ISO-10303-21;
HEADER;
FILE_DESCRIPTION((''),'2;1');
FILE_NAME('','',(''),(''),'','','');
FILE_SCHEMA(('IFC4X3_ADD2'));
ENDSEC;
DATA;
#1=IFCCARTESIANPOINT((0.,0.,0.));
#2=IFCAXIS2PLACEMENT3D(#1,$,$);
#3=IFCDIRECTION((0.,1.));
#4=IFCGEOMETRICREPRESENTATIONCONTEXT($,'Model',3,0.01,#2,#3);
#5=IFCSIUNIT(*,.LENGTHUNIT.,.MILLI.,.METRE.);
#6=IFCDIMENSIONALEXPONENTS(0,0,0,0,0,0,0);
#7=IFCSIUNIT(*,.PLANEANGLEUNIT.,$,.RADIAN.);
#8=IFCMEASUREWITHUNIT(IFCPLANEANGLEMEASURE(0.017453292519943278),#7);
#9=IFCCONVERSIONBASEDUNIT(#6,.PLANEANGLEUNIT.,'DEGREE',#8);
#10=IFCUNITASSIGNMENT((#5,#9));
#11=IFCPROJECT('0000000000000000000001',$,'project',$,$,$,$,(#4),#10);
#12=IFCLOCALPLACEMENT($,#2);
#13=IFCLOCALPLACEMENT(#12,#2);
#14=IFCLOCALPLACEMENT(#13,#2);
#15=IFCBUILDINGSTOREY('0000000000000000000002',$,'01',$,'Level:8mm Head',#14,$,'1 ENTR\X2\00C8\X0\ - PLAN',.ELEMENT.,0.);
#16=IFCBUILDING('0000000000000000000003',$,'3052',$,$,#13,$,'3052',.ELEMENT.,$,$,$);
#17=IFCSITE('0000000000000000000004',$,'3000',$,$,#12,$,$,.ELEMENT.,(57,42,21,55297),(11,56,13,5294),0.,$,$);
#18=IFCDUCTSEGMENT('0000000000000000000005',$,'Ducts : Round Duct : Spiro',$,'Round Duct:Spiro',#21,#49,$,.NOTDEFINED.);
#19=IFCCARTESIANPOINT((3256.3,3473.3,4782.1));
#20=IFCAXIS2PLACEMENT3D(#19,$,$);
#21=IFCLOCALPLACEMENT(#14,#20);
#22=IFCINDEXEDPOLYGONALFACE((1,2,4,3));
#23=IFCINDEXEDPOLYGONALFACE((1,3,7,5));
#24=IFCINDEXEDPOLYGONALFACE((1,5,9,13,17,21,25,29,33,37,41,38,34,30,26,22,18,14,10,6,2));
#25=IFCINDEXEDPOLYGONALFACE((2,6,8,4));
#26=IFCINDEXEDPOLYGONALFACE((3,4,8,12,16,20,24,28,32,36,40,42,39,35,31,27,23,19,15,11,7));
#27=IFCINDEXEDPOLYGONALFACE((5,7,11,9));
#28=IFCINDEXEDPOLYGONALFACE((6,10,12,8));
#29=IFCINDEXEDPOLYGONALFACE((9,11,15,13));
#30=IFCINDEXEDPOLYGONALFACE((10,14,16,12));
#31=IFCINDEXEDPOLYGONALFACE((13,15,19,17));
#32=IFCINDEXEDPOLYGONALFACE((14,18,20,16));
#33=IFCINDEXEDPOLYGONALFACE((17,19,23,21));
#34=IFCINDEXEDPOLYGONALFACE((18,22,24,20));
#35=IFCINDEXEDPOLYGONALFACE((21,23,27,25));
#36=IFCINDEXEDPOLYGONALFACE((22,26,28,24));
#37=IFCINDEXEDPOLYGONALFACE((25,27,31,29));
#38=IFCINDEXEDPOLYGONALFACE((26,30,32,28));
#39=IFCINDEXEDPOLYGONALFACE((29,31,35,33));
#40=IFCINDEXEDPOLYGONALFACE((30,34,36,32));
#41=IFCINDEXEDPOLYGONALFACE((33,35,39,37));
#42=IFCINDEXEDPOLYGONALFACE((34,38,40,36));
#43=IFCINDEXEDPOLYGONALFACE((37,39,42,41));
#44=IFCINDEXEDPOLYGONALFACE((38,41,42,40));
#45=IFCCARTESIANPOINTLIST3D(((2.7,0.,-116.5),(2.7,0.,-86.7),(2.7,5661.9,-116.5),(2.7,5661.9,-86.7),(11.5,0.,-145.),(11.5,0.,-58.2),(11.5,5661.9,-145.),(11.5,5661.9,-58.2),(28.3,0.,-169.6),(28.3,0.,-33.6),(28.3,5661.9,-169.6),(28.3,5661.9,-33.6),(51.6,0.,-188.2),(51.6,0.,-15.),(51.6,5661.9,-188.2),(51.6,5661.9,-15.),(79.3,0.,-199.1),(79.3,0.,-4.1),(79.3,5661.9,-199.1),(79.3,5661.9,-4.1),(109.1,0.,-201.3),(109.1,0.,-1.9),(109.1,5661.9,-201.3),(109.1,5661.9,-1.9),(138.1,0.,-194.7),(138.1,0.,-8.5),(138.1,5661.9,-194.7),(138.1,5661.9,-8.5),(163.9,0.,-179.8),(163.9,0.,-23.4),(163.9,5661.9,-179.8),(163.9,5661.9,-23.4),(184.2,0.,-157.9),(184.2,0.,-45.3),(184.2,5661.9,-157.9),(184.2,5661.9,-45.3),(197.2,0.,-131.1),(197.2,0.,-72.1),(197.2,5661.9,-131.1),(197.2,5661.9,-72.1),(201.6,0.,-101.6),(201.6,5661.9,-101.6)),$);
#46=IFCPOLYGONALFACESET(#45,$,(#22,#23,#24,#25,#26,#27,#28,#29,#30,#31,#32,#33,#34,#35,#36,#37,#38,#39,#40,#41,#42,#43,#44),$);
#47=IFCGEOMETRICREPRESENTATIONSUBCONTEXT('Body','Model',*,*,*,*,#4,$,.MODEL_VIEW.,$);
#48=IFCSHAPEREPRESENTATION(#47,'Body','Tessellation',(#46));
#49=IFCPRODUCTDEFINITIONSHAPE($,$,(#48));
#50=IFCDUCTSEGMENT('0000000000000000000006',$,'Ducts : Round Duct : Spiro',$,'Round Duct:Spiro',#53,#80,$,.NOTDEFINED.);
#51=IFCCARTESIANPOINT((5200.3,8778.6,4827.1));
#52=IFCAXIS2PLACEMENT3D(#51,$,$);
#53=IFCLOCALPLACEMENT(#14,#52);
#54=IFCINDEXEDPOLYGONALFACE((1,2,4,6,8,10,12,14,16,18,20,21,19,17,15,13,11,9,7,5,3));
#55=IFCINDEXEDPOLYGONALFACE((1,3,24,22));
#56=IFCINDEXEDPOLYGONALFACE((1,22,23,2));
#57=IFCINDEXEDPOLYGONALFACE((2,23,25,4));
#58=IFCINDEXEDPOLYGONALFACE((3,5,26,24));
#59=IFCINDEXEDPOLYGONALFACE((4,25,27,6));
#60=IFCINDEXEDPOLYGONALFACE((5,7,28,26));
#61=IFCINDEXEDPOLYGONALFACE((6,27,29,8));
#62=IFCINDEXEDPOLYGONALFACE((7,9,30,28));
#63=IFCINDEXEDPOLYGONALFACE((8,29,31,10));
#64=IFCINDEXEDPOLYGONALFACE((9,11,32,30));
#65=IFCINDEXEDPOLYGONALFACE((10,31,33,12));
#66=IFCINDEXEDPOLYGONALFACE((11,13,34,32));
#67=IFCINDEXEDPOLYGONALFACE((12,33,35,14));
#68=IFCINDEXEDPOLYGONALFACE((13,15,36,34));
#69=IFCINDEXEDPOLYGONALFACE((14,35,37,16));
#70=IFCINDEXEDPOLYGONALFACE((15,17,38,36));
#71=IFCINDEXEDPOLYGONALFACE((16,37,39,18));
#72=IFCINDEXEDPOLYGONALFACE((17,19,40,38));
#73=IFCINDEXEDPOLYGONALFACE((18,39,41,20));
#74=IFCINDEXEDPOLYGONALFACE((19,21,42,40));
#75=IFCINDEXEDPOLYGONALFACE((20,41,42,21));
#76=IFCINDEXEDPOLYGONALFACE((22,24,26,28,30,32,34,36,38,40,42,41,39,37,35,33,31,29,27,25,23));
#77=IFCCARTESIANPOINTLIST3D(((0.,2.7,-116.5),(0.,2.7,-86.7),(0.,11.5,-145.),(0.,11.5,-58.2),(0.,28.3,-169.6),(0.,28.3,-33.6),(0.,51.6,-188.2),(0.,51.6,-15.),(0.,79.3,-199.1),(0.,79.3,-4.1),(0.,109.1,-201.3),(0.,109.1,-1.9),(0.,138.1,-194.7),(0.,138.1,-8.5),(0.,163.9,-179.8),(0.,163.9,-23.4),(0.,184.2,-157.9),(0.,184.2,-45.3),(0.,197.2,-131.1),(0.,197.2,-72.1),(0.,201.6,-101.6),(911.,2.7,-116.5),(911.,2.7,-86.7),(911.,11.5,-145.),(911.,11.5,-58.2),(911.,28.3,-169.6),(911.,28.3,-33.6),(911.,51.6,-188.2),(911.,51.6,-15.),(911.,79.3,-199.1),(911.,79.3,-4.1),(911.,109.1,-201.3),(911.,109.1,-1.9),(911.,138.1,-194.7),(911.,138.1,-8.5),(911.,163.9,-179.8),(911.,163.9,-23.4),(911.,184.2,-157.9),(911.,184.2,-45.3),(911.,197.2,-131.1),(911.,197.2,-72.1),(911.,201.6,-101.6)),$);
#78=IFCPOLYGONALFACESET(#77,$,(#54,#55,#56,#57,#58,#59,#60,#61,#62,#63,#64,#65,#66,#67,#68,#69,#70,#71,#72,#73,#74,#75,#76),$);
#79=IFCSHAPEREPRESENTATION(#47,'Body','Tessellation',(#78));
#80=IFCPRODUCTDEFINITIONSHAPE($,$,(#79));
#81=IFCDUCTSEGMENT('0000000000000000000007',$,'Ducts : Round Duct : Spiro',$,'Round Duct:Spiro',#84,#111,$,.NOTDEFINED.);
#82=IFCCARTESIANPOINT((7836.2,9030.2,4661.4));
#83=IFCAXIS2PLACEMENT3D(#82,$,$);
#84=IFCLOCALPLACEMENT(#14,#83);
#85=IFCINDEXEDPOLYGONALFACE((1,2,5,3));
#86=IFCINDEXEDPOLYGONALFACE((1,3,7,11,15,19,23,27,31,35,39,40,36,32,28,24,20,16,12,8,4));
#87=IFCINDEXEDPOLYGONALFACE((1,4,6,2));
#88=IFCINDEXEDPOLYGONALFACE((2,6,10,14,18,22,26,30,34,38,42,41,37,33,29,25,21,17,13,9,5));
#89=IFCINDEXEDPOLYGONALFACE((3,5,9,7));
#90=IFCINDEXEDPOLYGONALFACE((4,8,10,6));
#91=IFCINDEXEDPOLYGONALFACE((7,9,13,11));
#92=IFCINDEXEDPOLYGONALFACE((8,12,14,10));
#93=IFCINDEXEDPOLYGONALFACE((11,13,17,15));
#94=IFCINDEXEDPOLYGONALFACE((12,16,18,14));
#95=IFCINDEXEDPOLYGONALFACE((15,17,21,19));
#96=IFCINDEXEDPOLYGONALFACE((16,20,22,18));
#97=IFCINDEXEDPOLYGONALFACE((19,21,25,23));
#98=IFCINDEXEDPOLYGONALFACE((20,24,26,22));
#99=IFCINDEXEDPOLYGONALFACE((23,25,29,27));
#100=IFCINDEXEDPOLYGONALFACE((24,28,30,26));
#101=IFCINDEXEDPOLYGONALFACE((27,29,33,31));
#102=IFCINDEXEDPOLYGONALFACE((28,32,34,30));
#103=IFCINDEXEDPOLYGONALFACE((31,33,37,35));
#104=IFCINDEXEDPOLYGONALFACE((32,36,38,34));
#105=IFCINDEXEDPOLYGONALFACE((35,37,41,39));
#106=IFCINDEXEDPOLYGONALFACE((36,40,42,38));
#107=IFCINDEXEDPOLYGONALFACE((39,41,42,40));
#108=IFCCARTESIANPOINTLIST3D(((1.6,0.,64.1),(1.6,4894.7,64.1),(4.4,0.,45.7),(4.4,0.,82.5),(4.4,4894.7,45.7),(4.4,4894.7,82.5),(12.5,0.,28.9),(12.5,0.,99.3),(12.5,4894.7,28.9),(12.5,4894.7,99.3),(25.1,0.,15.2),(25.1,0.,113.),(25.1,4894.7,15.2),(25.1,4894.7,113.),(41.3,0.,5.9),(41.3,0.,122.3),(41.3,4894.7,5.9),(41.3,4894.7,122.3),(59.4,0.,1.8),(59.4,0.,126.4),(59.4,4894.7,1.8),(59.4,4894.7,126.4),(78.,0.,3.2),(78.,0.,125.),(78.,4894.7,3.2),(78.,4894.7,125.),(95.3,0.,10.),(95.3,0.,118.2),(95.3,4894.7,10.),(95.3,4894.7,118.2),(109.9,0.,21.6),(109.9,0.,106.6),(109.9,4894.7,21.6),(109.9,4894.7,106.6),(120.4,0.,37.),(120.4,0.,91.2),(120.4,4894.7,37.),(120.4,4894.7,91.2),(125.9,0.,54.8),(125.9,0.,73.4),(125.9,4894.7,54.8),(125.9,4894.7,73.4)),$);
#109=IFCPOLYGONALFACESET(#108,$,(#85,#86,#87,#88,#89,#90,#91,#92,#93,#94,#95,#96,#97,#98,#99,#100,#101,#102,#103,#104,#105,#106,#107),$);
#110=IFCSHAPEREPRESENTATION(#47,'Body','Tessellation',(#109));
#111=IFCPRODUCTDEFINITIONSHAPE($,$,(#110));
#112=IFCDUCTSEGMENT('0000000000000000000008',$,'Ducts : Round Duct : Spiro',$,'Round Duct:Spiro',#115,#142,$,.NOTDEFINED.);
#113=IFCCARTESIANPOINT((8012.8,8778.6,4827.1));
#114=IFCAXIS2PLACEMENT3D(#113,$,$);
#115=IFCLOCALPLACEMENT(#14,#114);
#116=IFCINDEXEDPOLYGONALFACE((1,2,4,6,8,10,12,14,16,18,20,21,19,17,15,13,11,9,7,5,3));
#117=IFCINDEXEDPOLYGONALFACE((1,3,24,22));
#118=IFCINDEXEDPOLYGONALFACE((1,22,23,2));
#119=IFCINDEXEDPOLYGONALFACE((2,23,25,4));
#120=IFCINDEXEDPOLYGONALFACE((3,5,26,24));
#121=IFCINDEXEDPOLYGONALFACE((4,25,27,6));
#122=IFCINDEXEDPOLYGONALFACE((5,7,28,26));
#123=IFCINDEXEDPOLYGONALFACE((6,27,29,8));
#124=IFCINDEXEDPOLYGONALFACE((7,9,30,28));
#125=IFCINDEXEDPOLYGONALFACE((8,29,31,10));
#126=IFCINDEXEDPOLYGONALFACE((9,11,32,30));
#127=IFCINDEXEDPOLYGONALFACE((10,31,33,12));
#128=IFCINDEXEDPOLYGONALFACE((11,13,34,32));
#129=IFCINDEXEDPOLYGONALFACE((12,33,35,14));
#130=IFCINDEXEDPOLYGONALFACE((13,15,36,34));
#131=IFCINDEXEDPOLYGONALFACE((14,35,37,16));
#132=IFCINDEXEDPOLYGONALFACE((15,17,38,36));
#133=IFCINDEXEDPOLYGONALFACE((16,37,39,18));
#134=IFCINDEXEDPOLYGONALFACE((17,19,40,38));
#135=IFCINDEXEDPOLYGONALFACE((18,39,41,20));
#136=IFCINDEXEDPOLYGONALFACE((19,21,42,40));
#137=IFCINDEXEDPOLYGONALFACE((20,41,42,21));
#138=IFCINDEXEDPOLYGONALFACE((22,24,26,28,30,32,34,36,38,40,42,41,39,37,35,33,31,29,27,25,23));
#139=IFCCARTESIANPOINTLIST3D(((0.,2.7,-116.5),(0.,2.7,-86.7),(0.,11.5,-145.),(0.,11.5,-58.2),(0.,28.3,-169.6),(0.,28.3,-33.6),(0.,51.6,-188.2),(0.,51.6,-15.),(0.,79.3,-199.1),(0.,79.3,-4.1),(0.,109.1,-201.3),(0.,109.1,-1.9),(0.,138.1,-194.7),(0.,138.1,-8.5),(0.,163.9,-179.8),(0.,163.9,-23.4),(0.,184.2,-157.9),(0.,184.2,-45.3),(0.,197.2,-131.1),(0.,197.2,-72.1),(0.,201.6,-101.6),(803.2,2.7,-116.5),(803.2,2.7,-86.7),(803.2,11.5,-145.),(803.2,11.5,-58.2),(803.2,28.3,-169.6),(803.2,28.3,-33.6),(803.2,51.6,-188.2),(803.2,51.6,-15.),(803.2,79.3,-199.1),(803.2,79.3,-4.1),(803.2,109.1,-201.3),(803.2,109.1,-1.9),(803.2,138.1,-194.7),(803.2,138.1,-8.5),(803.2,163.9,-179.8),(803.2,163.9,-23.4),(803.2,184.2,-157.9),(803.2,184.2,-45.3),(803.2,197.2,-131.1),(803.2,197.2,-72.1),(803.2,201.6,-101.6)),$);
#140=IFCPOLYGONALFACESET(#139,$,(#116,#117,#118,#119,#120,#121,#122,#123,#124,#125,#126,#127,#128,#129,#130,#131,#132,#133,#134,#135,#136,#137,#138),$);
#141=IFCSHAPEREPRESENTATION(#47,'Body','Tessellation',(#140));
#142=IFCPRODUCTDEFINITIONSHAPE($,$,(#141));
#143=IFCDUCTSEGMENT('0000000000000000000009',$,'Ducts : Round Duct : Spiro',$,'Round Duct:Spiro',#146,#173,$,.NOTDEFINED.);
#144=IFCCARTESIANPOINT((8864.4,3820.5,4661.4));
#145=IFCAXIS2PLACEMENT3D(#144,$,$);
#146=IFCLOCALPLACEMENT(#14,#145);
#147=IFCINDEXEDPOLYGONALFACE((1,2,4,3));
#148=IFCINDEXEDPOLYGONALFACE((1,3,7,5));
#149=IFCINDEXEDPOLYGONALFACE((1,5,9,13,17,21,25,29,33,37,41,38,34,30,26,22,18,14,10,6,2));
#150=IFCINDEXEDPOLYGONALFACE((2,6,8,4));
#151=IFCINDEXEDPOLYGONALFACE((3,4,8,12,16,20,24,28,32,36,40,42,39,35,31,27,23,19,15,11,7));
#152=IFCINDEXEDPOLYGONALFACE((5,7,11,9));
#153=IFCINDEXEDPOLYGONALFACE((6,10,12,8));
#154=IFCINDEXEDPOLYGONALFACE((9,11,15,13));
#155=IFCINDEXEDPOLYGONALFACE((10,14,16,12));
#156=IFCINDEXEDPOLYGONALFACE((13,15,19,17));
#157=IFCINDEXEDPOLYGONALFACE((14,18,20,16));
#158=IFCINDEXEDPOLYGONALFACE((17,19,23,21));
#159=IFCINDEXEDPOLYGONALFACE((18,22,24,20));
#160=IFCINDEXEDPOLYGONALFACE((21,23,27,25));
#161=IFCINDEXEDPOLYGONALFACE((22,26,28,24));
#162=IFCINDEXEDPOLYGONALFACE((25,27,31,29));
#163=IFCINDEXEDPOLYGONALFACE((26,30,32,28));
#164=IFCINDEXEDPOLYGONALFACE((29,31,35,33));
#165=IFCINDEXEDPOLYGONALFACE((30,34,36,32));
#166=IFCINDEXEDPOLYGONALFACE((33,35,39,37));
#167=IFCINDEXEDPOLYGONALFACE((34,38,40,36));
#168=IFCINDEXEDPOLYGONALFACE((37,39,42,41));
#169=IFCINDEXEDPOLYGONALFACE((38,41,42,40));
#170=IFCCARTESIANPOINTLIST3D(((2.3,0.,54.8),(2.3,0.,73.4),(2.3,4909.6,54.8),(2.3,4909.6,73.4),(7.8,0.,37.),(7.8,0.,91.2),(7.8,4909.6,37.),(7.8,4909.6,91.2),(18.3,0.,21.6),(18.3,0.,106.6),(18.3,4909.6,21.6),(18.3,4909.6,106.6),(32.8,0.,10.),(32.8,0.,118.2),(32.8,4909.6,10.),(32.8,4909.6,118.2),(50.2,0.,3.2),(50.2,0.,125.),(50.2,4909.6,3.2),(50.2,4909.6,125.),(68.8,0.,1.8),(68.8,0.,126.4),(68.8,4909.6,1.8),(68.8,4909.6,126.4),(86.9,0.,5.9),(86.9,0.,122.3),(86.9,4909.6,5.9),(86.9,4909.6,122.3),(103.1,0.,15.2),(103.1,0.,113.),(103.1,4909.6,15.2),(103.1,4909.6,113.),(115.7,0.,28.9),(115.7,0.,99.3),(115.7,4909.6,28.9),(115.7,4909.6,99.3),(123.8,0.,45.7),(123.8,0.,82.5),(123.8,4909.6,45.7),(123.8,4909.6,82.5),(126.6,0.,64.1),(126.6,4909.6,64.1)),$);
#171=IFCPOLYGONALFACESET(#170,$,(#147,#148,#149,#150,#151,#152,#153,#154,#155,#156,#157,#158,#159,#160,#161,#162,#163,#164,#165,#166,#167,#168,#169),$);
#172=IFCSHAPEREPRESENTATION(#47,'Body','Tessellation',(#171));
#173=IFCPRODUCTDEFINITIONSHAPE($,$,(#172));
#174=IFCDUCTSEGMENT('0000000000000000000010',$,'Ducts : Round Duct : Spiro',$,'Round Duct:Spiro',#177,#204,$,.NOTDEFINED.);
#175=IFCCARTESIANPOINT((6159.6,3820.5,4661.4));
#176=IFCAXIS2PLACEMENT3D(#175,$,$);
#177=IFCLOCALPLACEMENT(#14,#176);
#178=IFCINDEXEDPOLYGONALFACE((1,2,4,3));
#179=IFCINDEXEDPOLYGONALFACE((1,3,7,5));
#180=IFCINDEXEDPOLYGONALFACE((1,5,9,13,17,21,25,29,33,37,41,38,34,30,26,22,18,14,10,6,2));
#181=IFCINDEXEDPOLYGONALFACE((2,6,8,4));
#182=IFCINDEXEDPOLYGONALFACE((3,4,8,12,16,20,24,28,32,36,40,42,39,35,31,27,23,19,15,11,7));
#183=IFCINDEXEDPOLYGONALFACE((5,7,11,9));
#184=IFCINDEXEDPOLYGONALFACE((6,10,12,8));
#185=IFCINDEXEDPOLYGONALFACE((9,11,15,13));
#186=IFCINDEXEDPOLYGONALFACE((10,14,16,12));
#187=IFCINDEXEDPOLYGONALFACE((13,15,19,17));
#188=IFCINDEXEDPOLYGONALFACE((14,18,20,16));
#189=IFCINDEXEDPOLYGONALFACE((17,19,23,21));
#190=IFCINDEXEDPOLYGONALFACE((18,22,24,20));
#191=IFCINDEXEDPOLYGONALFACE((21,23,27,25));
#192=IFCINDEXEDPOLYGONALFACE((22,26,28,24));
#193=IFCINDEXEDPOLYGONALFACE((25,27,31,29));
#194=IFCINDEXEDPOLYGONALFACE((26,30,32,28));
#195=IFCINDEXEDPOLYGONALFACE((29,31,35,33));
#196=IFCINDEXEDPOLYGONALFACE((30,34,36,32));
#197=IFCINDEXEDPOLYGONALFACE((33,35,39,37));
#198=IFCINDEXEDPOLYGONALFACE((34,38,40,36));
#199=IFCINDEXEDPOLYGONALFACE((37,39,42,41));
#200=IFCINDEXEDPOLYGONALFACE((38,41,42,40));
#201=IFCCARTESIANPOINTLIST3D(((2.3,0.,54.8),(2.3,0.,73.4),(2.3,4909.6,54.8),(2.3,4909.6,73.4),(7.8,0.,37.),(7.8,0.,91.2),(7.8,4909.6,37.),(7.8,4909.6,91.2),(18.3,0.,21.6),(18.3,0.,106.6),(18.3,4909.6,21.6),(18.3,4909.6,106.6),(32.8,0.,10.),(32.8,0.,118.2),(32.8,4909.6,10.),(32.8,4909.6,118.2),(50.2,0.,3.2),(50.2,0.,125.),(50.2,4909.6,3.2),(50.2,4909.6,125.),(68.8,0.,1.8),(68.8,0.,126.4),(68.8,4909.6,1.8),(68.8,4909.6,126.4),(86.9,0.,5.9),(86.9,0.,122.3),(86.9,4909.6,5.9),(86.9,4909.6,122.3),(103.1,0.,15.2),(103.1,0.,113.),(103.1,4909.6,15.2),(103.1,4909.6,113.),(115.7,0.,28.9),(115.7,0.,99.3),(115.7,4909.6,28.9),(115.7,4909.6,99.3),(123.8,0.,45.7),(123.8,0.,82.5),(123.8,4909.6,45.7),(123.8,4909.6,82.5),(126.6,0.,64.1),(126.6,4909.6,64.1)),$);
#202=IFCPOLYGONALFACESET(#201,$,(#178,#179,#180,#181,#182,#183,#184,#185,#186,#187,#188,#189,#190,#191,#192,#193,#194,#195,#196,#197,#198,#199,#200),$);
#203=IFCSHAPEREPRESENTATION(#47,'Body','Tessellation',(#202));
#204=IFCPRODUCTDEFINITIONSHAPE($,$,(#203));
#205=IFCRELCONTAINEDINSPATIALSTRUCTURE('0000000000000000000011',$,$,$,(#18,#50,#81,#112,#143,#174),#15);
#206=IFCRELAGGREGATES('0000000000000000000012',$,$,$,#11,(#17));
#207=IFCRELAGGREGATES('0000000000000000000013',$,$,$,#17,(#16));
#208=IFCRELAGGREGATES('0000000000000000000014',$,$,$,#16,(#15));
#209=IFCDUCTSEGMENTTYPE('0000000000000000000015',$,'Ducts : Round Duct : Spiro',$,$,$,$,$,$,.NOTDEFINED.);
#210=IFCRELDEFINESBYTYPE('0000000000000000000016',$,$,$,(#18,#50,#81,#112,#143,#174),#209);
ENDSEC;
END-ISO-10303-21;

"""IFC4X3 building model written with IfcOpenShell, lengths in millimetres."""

from ifc_helpers import new_model, entity, si_unit, converted_unit, direction, frame, frame_2d, origin, origin_2d_with_axis, place, context, subcontext, project, spatial, circle, extrude, type_object, element, save


model = new_model("IFC4X3")

# Units and contexts
model_context = context("Model", 3, precision=0.01, world=origin(), true_north=direction((0.0, 1.0)))
body_context = subcontext(model_context, "Body", "Model", "MODEL_VIEW")
ifc_project = project(units=[si_unit("LENGTHUNIT", "METRE", prefix="MILLI"), converted_unit("PLANEANGLEUNIT", "DEGREE", entity("IfcPlaneAngleMeasure", 0.017453292519943278), si_unit("PLANEANGLEUNIT", "RADIAN"), dimensions=[0, 0, 0, 0, 0, 0, 0])], contexts=[model_context])

# Site, building, storey
site_placement = place(None, origin())
site = spatial("IfcSite", under=ifc_project, at=site_placement, Name="3000", CompositionType="ELEMENT", RefLatitude=(57, 42, 21, 55297), RefLongitude=(11, 56, 13, 5294), RefElevation=0.0)
building_placement = place(site_placement, origin())
building = spatial("IfcBuilding", under=site, at=building_placement, Name="3052", LongName="3052", CompositionType="ELEMENT")
storey_placement = place(building_placement, origin())
storey = spatial("IfcBuildingStorey", under=building, at=storey_placement, Name="01", ObjectType="Level:8mm Head", LongName="1 ENTRÈ - PLAN", CompositionType="ELEMENT", Elevation=0.0)

# Duct segments
duct_segment_type = type_object("IfcDuctSegmentType", Name="Ducts : Round Duct : Spiro", PredefinedType="NOTDEFINED")
duct_segment_1_placement = place(storey_placement, frame((3256.3, 3473.3, 4782.1)))
element("IfcDuctSegment", 1, at=duct_segment_1_placement, inside=storey, type_object=duct_segment_type, Name="Ducts : Round Duct : Spiro", ObjectType="Round Duct:Spiro", PredefinedType="NOTDEFINED", context=body_context, shape_type="SweptSolid", body=[
    extrude(circle(Radius=100.0, at=frame_2d((0.0, 0.0), x_axis=(1.0, 0.0))), frame((101.6, 0.0, -101.6), z_axis=(0.0, 1.0, 0.0), x_axis=(1.0, 0.0, 0.0)), (0.0, 0.0, 1.0), 5661.9),
])
duct_segment_2_placement = place(storey_placement, frame((5200.3, 8778.6, 4827.1)))
element("IfcDuctSegment", 2, at=duct_segment_2_placement, inside=storey, type_object=duct_segment_type, Name="Ducts : Round Duct : Spiro", ObjectType="Round Duct:Spiro", PredefinedType="NOTDEFINED", context=body_context, shape_type="SweptSolid", body=[
    extrude(circle(Radius=100.0, at=frame_2d((0.0, 0.0), x_axis=(1.0, 0.0))), frame((0.0, 101.6, -101.6), z_axis=(1.0, 0.0, 0.0), x_axis=(0.0, 1.0, 0.0)), (0.0, 0.0, 1.0), 911.0),
])
duct_segment_3_placement = place(storey_placement, frame((7836.2, 9030.2, 4661.4)))
element("IfcDuctSegment", 3, at=duct_segment_3_placement, inside=storey, type_object=duct_segment_type, Name="Ducts : Round Duct : Spiro", ObjectType="Round Duct:Spiro", PredefinedType="NOTDEFINED", context=body_context, shape_type="SweptSolid", body=[
    extrude(circle(Radius=62.5, at=origin_2d_with_axis()), frame((64.1, 0.0, 64.1), z_axis=(0.0, 1.0, 0.0), x_axis=(-1.0, 0.0, 0.0)), (0.0, 0.0, 1.0), 4894.7),
])
duct_segment_4_placement = place(storey_placement, frame((8012.8, 8778.6, 4827.1)))
element("IfcDuctSegment", 4, at=duct_segment_4_placement, inside=storey, type_object=duct_segment_type, Name="Ducts : Round Duct : Spiro", ObjectType="Round Duct:Spiro", PredefinedType="NOTDEFINED", context=body_context, shape_type="SweptSolid", body=[
    extrude(circle(Radius=100.0, at=frame_2d((0.0, 0.0), x_axis=(1.0, 0.0))), frame((0.0, 101.6, -101.6), z_axis=(1.0, 0.0, 0.0), x_axis=(0.0, 1.0, 0.0)), (0.0, 0.0, 1.0), 803.2),
])
duct_segment_5_placement = place(storey_placement, frame((8864.4, 3820.5, 4661.4)))
element("IfcDuctSegment", 5, at=duct_segment_5_placement, inside=storey, type_object=duct_segment_type, Name="Ducts : Round Duct : Spiro", ObjectType="Round Duct:Spiro", PredefinedType="NOTDEFINED", context=body_context, shape_type="SweptSolid", body=[
    extrude(circle(Radius=62.5, at=origin_2d_with_axis()), frame((64.1, 0.0, 64.1), z_axis=(0.0, 1.0, 0.0), x_axis=(1.0, 0.0, 0.0)), (0.0, 0.0, 1.0), 4909.6),
])
duct_segment_6_placement = place(storey_placement, frame((6159.6, 3820.5, 4661.4)))
element("IfcDuctSegment", 6, at=duct_segment_6_placement, inside=storey, type_object=duct_segment_type, Name="Ducts : Round Duct : Spiro", ObjectType="Round Duct:Spiro", PredefinedType="NOTDEFINED", context=body_context, shape_type="SweptSolid", body=[
    extrude(circle(Radius=62.5, at=origin_2d_with_axis()), frame((64.1, 0.0, 64.1), z_axis=(0.0, 1.0, 0.0), x_axis=(1.0, 0.0, 0.0)), (0.0, 0.0, 1.0), 4909.6),
])

save(model, "model.ifc")
